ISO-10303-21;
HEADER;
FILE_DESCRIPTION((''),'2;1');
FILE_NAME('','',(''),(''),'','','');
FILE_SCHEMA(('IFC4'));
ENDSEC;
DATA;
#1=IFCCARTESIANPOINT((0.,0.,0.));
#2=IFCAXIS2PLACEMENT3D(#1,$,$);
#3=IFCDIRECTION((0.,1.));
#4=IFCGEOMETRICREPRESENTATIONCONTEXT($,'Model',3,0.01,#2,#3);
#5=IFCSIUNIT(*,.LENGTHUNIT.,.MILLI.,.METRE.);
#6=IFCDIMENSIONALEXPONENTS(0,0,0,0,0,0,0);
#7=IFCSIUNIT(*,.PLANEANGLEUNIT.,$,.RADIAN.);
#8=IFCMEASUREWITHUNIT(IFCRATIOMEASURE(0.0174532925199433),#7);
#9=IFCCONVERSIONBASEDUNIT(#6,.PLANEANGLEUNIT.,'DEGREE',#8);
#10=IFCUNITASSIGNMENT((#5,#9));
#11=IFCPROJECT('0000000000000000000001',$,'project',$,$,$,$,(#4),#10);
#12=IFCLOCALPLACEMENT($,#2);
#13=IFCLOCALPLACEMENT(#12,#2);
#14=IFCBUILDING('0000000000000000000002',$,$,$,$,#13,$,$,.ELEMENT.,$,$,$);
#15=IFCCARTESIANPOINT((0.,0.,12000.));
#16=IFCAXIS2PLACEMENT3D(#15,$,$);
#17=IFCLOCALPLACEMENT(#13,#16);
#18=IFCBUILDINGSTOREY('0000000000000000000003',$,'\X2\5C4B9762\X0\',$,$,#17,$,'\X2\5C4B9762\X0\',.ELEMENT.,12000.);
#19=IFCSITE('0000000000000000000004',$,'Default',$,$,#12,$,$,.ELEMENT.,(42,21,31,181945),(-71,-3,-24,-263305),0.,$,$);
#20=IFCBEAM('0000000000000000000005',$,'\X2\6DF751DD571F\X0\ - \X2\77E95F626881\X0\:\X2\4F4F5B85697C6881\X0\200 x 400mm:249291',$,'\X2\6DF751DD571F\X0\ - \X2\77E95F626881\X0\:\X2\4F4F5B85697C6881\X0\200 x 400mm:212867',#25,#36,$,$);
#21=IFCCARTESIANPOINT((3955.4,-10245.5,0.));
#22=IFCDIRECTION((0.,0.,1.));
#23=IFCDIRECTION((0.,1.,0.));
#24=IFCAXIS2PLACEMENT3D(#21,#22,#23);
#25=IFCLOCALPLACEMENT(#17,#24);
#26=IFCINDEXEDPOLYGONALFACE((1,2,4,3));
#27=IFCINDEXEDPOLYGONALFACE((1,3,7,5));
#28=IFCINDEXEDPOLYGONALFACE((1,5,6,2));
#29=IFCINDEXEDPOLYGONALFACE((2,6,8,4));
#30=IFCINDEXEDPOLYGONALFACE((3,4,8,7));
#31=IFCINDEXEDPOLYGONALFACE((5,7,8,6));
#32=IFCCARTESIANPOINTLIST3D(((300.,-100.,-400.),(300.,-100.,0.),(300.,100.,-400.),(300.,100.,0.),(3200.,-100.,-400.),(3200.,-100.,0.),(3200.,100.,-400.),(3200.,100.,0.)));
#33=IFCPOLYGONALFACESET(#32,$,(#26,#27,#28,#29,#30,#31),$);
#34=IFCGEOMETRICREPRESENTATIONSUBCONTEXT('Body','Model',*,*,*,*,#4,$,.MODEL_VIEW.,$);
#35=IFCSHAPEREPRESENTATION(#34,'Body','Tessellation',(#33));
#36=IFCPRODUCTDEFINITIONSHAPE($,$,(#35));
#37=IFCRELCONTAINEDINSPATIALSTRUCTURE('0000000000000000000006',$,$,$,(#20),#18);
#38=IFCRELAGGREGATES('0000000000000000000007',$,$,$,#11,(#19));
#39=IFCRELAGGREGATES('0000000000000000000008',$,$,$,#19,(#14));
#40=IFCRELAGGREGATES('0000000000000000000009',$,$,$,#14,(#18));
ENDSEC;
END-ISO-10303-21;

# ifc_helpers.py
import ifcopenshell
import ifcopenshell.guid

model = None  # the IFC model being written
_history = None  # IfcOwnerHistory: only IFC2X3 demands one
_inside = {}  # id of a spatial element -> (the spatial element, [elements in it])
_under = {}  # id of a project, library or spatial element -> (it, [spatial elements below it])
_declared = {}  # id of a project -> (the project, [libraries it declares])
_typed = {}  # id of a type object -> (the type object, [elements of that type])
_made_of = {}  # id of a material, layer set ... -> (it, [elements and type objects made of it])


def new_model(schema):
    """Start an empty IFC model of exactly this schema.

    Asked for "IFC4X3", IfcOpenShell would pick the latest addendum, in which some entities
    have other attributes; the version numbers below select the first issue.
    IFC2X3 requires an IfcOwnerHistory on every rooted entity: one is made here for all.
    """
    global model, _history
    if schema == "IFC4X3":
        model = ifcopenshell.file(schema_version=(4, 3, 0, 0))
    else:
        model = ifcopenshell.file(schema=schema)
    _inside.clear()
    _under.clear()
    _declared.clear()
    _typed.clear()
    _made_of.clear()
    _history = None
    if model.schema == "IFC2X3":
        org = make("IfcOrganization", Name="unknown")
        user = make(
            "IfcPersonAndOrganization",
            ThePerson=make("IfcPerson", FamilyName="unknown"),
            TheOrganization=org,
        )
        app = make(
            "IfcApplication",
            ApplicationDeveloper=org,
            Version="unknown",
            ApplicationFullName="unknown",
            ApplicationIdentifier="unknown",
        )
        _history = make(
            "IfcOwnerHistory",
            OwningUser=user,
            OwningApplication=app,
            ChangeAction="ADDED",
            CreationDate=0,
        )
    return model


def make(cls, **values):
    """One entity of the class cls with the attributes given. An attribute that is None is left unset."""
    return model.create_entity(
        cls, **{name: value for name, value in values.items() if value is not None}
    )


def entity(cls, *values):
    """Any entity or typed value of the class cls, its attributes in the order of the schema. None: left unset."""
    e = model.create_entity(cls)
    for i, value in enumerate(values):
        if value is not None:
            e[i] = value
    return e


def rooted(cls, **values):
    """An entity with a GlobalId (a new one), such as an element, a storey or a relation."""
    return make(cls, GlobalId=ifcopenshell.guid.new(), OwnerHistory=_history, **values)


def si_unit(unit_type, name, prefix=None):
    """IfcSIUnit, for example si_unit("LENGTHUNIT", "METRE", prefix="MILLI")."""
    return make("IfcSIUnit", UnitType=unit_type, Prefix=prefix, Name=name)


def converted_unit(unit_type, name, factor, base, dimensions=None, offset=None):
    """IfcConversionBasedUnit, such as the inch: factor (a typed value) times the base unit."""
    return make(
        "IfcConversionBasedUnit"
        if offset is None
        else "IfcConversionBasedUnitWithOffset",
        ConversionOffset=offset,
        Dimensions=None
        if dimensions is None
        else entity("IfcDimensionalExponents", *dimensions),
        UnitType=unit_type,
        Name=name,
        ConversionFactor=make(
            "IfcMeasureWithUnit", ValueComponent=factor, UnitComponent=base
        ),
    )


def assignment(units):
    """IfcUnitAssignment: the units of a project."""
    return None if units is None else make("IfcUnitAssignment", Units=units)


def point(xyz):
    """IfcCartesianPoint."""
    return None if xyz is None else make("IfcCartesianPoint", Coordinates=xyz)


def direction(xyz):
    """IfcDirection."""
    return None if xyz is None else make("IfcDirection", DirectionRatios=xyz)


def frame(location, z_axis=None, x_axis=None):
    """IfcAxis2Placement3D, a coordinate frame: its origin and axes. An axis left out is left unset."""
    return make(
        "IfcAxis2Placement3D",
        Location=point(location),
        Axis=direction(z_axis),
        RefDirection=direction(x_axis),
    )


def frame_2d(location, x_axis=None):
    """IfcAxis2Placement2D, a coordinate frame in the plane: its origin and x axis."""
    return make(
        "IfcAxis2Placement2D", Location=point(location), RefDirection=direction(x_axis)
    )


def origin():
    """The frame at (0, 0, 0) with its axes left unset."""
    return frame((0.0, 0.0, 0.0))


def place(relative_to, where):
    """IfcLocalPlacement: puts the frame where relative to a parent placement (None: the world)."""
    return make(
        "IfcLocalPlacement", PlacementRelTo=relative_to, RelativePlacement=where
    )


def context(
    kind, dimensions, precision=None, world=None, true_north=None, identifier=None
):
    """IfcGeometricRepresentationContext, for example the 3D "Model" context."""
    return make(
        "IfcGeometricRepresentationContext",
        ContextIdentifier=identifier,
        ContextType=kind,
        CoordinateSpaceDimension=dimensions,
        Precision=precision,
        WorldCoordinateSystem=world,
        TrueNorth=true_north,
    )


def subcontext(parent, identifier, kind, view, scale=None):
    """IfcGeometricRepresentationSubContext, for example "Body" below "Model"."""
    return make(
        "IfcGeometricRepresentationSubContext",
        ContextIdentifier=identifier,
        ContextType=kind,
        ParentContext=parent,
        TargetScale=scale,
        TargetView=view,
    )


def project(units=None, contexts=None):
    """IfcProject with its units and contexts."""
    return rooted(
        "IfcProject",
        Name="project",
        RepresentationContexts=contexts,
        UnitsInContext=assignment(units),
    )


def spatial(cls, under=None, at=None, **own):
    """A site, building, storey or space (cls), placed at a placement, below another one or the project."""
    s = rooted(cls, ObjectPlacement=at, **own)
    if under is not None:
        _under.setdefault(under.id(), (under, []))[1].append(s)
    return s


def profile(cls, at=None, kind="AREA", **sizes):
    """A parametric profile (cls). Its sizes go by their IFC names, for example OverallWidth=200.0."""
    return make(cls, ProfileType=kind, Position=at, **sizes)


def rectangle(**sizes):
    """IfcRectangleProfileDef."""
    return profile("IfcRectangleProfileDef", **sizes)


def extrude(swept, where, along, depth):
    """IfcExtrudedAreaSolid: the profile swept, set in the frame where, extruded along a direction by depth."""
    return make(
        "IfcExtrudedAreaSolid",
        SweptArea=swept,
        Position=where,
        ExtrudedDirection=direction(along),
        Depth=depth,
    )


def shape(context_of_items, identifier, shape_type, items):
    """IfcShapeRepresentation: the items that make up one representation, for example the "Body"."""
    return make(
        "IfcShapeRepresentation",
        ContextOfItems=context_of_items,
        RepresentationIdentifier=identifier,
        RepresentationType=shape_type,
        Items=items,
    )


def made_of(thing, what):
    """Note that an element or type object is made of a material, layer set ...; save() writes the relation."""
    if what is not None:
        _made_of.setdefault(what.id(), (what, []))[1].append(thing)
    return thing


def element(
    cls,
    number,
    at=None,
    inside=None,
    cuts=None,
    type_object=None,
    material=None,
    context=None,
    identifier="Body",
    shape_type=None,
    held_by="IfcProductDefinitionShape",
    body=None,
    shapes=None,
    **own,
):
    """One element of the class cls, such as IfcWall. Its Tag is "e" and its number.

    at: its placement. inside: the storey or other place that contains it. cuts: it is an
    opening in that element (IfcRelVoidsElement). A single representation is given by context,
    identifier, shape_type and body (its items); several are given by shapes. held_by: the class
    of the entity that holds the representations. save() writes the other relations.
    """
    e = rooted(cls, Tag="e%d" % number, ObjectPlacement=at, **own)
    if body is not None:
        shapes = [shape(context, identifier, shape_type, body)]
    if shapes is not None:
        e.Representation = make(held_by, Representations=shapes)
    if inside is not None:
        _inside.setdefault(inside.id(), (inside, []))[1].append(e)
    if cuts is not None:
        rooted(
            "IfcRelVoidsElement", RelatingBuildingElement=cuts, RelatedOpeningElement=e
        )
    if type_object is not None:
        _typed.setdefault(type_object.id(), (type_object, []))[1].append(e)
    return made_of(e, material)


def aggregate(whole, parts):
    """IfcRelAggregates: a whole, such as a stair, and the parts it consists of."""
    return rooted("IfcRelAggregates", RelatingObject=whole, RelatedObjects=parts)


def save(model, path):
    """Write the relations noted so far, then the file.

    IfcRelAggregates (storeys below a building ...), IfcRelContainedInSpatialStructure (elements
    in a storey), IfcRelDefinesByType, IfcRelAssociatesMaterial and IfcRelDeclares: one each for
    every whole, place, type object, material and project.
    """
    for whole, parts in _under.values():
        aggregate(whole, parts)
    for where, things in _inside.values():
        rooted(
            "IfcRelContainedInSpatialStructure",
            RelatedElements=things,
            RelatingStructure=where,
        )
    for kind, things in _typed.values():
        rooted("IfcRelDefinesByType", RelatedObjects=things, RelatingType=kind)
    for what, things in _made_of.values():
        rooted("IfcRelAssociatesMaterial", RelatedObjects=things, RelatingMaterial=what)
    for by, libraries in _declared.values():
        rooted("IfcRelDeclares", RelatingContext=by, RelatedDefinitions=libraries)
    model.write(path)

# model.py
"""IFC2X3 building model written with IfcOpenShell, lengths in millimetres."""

from ifc_helpers import new_model, entity, si_unit, converted_unit, direction, frame, frame_2d, origin, place, context, subcontext, project, spatial, rectangle, extrude, element, save


model = new_model("IFC2X3")

# Units and contexts
model_context = context("Model", 3, precision=0.01, world=origin(), true_north=direction((0.0, 1.0)))
body_context = subcontext(model_context, "Body", "Model", "MODEL_VIEW")
ifc_project = project(units=[si_unit("LENGTHUNIT", "METRE", prefix="MILLI"), converted_unit("PLANEANGLEUNIT", "DEGREE", entity("IfcRatioMeasure", 0.0174532925199433), si_unit("PLANEANGLEUNIT", "RADIAN"), dimensions=[0, 0, 0, 0, 0, 0, 0])], contexts=[model_context])

# Site, building, storey
site_placement = place(None, origin())
site = spatial("IfcSite", under=ifc_project, at=site_placement, Name="Default", CompositionType="ELEMENT", RefLatitude=(42, 21, 31, 181945), RefLongitude=(-71, -3, -24, -263305), RefElevation=0.0)
building_placement = place(site_placement, origin())
building = spatial("IfcBuilding", under=site, at=building_placement, CompositionType="ELEMENT")
storey_placement = place(building_placement, frame((0.0, 0.0, 12000.0)))
storey = spatial("IfcBuildingStorey", under=building, at=storey_placement, Name="屋面", LongName="屋面", CompositionType="ELEMENT", Elevation=12000.0)

# Beam
beam_1_placement = place(storey_placement, frame((3955.4, -10245.5, 0.0), z_axis=(0.0, 0.0, 1.0), x_axis=(0.0, 1.0, 0.0)))
element("IfcBeam", 1, at=beam_1_placement, inside=storey, Name="混凝土 - 矩形梁:住宅楼梁200 x 400mm:249291", ObjectType="混凝土 - 矩形梁:住宅楼梁200 x 400mm:212867", context=body_context, shape_type="SweptSolid", body=[
    extrude(rectangle(XDim=400.0, YDim=200.0, at=frame_2d((0.0, 0.0), x_axis=(1.0, 0.0))), frame((300.0, 0.0, -200.0), z_axis=(1.0, 0.0, 0.0), x_axis=(0.0, 0.0, -1.0)), (0.0, 0.0, 1.0), 2900.0),
])

save(model, "model.ifc")
